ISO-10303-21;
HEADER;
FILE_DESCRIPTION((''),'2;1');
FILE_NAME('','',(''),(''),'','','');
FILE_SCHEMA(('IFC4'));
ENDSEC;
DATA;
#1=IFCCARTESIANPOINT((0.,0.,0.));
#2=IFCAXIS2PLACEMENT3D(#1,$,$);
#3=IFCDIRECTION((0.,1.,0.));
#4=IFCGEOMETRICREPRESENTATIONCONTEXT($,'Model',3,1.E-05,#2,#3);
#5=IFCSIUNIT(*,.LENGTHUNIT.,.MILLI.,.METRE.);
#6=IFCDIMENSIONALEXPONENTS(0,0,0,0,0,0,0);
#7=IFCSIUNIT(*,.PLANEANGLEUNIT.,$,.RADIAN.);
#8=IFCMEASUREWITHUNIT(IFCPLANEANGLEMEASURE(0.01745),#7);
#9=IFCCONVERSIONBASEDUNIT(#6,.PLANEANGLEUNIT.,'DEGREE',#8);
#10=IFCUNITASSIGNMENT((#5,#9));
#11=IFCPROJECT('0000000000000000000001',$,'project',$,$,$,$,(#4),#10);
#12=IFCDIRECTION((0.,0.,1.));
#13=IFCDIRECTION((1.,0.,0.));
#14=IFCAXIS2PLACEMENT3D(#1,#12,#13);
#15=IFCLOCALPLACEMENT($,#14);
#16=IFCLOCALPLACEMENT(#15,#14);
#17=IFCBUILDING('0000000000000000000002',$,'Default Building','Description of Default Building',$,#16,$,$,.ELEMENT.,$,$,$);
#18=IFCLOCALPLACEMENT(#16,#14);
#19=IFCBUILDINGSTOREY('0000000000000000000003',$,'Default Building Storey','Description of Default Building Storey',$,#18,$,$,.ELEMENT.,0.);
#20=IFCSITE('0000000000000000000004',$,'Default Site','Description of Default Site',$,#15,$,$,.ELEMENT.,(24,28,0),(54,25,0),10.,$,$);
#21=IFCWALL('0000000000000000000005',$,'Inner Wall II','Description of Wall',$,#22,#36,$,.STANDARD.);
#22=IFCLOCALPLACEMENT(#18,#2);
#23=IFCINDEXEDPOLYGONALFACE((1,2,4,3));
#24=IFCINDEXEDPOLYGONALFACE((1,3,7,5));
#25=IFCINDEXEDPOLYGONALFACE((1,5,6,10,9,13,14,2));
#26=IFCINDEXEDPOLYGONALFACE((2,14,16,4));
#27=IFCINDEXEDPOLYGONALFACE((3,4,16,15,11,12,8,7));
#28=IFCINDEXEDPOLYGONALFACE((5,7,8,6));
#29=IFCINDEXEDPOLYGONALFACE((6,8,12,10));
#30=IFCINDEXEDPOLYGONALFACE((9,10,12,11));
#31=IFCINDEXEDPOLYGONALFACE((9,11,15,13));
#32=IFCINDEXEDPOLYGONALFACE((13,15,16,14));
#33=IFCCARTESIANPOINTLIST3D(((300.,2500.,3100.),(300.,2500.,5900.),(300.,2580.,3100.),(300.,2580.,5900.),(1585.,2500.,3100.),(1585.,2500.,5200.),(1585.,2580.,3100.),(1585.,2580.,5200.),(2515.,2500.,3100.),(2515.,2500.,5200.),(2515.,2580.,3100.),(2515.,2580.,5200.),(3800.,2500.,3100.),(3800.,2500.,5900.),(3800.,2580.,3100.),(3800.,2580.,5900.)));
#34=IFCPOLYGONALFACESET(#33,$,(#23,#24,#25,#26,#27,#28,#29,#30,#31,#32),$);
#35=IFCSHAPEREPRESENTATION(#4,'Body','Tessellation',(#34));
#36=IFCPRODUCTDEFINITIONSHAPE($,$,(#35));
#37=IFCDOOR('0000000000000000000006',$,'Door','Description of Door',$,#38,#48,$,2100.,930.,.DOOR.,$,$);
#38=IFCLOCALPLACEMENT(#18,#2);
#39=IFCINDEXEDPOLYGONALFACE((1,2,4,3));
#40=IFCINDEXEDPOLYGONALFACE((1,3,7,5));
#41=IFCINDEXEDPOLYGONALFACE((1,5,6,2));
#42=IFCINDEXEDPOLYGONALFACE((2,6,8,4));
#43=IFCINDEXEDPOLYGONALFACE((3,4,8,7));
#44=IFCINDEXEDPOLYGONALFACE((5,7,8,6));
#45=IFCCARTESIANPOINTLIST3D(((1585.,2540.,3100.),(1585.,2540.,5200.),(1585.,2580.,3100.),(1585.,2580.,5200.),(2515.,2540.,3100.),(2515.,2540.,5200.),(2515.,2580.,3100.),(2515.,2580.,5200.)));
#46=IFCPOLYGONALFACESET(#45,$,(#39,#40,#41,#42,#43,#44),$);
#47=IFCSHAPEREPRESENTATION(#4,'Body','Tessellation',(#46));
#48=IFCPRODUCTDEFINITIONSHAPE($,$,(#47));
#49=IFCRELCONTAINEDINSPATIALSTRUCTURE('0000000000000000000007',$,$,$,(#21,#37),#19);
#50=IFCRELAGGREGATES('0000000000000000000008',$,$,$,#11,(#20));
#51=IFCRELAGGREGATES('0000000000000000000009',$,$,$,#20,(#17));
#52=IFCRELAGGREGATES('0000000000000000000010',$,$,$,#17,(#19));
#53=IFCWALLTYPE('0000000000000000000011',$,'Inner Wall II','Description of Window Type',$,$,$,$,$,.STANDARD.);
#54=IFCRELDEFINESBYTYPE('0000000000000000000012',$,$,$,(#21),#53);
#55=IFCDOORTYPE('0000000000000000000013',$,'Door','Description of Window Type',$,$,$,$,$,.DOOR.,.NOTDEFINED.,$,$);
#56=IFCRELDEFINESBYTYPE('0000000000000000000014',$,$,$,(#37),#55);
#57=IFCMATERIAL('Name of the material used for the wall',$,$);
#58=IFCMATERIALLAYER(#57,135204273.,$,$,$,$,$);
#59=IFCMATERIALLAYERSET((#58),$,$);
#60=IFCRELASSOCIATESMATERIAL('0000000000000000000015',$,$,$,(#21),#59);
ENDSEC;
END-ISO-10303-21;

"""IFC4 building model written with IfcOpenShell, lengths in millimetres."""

from ifc_helpers import new_model, entity, si_unit, converted_unit, direction, frame, origin, origin_with_axes, place, context, project, spatial, polyline, outline, extrude, material, layer, layer_set, layer_usage, type_object, element, fill, save


model = new_model("IFC4")

# Units and contexts
model_context = context("Model", 3, precision=1e-05, world=origin(), true_north=direction((0.0, 1.0, 0.0)))
ifc_project = project(units=[si_unit("LENGTHUNIT", "METRE", prefix="MILLI"), converted_unit("PLANEANGLEUNIT", "DEGREE", entity("IfcPlaneAngleMeasure", 0.01745), si_unit("PLANEANGLEUNIT", "RADIAN"), dimensions=[0, 0, 0, 0, 0, 0, 0])], contexts=[model_context])

# Site, building, storey
site_placement = place(None, origin_with_axes())
site = spatial("IfcSite", under=ifc_project, at=site_placement, Name="Default Site", Description="Description of Default Site", CompositionType="ELEMENT", RefLatitude=(24, 28, 0), RefLongitude=(54, 25, 0), RefElevation=10.0)
building_placement = place(site_placement, origin_with_axes())
building = spatial("IfcBuilding", under=site, at=building_placement, Name="Default Building", Description="Description of Default Building", CompositionType="ELEMENT")
storey_placement = place(building_placement, origin_with_axes())
storey = spatial("IfcBuildingStorey", under=building, at=storey_placement, Name="Default Building Storey", Description="Description of Default Building Storey", CompositionType="ELEMENT", Elevation=0.0)

# Wall, opening, door
ifc_material_1 = material(Name="Name of the material used for the wall")
ifc_layer_1 = layer(ifc_material_1, 135204273.0)
ifc_layer_set_1 = layer_set([ifc_layer_1])
ifc_layer_usage_1 = layer_usage(ifc_layer_set_1, "AXIS2", "POSITIVE", -67602136.5)
wall_type_1 = type_object("IfcWallType", Name="Inner Wall II", Description="Description of Window Type", PredefinedType="STANDARD")
wall_1_placement = place(storey_placement, frame((3800.0, 2540.0, 3100.0), z_axis=(0.0, 0.0, 1.0), x_axis=(-1.0, 0.0, 0.0)))
wall_1 = element("IfcWall", 1, at=wall_1_placement, inside=storey, type_object=wall_type_1, material=ifc_layer_usage_1, Name="Inner Wall II", Description="Description of Wall", PredefinedType="STANDARD", context=model_context, shape_type="SweptSolid", body=[
    extrude(outline(polyline([(0.0, -40.0), (0.0, 40.0), (3500.0, 40.0), (3500.0, -40.0), (0.0, -40.0)])), origin_with_axes(), (0.0, 0.0, 1.0), 2800.0),
])
opening_1_placement = place(wall_1_placement, frame((1285.0, -40.0, 0.0), z_axis=(0.0, 0.0, 1.0), x_axis=(1.0, 0.0, 0.0)))
opening_1 = element("IfcOpeningElement", 2, at=opening_1_placement, cuts=wall_1, context=model_context, shape_type="SweptSolid", body=[
    extrude(outline(polyline([(0.0, 0.0), (0.0, 80.0), (930.0, 80.0), (930.0, 0.0), (0.0, 0.0)])), origin_with_axes(), (0.0, 0.0, 1.0), 2100.0),
])
door_type_1 = type_object("IfcDoorType", Name="Door", Description="Description of Window Type", PredefinedType="DOOR")
door_1_placement = place(opening_1_placement, origin_with_axes())
door_1 = element("IfcDoor", 3, at=door_1_placement, inside=storey, type_object=door_type_1, Name="Door", Description="Description of Door", OverallHeight=2100.0, OverallWidth=930.0, PredefinedType="DOOR", context=model_context, shape_type="SweptSolid", body=[
    extrude(outline(polyline([(0.0, 0.0), (0.0, 40.0), (930.0, 40.0), (930.0, 0.0), (0.0, 0.0)])), origin_with_axes(), (0.0, 0.0, 1.0), 2100.0),
])
fill(opening_1, door_1)

save(model, "model.ifc")
